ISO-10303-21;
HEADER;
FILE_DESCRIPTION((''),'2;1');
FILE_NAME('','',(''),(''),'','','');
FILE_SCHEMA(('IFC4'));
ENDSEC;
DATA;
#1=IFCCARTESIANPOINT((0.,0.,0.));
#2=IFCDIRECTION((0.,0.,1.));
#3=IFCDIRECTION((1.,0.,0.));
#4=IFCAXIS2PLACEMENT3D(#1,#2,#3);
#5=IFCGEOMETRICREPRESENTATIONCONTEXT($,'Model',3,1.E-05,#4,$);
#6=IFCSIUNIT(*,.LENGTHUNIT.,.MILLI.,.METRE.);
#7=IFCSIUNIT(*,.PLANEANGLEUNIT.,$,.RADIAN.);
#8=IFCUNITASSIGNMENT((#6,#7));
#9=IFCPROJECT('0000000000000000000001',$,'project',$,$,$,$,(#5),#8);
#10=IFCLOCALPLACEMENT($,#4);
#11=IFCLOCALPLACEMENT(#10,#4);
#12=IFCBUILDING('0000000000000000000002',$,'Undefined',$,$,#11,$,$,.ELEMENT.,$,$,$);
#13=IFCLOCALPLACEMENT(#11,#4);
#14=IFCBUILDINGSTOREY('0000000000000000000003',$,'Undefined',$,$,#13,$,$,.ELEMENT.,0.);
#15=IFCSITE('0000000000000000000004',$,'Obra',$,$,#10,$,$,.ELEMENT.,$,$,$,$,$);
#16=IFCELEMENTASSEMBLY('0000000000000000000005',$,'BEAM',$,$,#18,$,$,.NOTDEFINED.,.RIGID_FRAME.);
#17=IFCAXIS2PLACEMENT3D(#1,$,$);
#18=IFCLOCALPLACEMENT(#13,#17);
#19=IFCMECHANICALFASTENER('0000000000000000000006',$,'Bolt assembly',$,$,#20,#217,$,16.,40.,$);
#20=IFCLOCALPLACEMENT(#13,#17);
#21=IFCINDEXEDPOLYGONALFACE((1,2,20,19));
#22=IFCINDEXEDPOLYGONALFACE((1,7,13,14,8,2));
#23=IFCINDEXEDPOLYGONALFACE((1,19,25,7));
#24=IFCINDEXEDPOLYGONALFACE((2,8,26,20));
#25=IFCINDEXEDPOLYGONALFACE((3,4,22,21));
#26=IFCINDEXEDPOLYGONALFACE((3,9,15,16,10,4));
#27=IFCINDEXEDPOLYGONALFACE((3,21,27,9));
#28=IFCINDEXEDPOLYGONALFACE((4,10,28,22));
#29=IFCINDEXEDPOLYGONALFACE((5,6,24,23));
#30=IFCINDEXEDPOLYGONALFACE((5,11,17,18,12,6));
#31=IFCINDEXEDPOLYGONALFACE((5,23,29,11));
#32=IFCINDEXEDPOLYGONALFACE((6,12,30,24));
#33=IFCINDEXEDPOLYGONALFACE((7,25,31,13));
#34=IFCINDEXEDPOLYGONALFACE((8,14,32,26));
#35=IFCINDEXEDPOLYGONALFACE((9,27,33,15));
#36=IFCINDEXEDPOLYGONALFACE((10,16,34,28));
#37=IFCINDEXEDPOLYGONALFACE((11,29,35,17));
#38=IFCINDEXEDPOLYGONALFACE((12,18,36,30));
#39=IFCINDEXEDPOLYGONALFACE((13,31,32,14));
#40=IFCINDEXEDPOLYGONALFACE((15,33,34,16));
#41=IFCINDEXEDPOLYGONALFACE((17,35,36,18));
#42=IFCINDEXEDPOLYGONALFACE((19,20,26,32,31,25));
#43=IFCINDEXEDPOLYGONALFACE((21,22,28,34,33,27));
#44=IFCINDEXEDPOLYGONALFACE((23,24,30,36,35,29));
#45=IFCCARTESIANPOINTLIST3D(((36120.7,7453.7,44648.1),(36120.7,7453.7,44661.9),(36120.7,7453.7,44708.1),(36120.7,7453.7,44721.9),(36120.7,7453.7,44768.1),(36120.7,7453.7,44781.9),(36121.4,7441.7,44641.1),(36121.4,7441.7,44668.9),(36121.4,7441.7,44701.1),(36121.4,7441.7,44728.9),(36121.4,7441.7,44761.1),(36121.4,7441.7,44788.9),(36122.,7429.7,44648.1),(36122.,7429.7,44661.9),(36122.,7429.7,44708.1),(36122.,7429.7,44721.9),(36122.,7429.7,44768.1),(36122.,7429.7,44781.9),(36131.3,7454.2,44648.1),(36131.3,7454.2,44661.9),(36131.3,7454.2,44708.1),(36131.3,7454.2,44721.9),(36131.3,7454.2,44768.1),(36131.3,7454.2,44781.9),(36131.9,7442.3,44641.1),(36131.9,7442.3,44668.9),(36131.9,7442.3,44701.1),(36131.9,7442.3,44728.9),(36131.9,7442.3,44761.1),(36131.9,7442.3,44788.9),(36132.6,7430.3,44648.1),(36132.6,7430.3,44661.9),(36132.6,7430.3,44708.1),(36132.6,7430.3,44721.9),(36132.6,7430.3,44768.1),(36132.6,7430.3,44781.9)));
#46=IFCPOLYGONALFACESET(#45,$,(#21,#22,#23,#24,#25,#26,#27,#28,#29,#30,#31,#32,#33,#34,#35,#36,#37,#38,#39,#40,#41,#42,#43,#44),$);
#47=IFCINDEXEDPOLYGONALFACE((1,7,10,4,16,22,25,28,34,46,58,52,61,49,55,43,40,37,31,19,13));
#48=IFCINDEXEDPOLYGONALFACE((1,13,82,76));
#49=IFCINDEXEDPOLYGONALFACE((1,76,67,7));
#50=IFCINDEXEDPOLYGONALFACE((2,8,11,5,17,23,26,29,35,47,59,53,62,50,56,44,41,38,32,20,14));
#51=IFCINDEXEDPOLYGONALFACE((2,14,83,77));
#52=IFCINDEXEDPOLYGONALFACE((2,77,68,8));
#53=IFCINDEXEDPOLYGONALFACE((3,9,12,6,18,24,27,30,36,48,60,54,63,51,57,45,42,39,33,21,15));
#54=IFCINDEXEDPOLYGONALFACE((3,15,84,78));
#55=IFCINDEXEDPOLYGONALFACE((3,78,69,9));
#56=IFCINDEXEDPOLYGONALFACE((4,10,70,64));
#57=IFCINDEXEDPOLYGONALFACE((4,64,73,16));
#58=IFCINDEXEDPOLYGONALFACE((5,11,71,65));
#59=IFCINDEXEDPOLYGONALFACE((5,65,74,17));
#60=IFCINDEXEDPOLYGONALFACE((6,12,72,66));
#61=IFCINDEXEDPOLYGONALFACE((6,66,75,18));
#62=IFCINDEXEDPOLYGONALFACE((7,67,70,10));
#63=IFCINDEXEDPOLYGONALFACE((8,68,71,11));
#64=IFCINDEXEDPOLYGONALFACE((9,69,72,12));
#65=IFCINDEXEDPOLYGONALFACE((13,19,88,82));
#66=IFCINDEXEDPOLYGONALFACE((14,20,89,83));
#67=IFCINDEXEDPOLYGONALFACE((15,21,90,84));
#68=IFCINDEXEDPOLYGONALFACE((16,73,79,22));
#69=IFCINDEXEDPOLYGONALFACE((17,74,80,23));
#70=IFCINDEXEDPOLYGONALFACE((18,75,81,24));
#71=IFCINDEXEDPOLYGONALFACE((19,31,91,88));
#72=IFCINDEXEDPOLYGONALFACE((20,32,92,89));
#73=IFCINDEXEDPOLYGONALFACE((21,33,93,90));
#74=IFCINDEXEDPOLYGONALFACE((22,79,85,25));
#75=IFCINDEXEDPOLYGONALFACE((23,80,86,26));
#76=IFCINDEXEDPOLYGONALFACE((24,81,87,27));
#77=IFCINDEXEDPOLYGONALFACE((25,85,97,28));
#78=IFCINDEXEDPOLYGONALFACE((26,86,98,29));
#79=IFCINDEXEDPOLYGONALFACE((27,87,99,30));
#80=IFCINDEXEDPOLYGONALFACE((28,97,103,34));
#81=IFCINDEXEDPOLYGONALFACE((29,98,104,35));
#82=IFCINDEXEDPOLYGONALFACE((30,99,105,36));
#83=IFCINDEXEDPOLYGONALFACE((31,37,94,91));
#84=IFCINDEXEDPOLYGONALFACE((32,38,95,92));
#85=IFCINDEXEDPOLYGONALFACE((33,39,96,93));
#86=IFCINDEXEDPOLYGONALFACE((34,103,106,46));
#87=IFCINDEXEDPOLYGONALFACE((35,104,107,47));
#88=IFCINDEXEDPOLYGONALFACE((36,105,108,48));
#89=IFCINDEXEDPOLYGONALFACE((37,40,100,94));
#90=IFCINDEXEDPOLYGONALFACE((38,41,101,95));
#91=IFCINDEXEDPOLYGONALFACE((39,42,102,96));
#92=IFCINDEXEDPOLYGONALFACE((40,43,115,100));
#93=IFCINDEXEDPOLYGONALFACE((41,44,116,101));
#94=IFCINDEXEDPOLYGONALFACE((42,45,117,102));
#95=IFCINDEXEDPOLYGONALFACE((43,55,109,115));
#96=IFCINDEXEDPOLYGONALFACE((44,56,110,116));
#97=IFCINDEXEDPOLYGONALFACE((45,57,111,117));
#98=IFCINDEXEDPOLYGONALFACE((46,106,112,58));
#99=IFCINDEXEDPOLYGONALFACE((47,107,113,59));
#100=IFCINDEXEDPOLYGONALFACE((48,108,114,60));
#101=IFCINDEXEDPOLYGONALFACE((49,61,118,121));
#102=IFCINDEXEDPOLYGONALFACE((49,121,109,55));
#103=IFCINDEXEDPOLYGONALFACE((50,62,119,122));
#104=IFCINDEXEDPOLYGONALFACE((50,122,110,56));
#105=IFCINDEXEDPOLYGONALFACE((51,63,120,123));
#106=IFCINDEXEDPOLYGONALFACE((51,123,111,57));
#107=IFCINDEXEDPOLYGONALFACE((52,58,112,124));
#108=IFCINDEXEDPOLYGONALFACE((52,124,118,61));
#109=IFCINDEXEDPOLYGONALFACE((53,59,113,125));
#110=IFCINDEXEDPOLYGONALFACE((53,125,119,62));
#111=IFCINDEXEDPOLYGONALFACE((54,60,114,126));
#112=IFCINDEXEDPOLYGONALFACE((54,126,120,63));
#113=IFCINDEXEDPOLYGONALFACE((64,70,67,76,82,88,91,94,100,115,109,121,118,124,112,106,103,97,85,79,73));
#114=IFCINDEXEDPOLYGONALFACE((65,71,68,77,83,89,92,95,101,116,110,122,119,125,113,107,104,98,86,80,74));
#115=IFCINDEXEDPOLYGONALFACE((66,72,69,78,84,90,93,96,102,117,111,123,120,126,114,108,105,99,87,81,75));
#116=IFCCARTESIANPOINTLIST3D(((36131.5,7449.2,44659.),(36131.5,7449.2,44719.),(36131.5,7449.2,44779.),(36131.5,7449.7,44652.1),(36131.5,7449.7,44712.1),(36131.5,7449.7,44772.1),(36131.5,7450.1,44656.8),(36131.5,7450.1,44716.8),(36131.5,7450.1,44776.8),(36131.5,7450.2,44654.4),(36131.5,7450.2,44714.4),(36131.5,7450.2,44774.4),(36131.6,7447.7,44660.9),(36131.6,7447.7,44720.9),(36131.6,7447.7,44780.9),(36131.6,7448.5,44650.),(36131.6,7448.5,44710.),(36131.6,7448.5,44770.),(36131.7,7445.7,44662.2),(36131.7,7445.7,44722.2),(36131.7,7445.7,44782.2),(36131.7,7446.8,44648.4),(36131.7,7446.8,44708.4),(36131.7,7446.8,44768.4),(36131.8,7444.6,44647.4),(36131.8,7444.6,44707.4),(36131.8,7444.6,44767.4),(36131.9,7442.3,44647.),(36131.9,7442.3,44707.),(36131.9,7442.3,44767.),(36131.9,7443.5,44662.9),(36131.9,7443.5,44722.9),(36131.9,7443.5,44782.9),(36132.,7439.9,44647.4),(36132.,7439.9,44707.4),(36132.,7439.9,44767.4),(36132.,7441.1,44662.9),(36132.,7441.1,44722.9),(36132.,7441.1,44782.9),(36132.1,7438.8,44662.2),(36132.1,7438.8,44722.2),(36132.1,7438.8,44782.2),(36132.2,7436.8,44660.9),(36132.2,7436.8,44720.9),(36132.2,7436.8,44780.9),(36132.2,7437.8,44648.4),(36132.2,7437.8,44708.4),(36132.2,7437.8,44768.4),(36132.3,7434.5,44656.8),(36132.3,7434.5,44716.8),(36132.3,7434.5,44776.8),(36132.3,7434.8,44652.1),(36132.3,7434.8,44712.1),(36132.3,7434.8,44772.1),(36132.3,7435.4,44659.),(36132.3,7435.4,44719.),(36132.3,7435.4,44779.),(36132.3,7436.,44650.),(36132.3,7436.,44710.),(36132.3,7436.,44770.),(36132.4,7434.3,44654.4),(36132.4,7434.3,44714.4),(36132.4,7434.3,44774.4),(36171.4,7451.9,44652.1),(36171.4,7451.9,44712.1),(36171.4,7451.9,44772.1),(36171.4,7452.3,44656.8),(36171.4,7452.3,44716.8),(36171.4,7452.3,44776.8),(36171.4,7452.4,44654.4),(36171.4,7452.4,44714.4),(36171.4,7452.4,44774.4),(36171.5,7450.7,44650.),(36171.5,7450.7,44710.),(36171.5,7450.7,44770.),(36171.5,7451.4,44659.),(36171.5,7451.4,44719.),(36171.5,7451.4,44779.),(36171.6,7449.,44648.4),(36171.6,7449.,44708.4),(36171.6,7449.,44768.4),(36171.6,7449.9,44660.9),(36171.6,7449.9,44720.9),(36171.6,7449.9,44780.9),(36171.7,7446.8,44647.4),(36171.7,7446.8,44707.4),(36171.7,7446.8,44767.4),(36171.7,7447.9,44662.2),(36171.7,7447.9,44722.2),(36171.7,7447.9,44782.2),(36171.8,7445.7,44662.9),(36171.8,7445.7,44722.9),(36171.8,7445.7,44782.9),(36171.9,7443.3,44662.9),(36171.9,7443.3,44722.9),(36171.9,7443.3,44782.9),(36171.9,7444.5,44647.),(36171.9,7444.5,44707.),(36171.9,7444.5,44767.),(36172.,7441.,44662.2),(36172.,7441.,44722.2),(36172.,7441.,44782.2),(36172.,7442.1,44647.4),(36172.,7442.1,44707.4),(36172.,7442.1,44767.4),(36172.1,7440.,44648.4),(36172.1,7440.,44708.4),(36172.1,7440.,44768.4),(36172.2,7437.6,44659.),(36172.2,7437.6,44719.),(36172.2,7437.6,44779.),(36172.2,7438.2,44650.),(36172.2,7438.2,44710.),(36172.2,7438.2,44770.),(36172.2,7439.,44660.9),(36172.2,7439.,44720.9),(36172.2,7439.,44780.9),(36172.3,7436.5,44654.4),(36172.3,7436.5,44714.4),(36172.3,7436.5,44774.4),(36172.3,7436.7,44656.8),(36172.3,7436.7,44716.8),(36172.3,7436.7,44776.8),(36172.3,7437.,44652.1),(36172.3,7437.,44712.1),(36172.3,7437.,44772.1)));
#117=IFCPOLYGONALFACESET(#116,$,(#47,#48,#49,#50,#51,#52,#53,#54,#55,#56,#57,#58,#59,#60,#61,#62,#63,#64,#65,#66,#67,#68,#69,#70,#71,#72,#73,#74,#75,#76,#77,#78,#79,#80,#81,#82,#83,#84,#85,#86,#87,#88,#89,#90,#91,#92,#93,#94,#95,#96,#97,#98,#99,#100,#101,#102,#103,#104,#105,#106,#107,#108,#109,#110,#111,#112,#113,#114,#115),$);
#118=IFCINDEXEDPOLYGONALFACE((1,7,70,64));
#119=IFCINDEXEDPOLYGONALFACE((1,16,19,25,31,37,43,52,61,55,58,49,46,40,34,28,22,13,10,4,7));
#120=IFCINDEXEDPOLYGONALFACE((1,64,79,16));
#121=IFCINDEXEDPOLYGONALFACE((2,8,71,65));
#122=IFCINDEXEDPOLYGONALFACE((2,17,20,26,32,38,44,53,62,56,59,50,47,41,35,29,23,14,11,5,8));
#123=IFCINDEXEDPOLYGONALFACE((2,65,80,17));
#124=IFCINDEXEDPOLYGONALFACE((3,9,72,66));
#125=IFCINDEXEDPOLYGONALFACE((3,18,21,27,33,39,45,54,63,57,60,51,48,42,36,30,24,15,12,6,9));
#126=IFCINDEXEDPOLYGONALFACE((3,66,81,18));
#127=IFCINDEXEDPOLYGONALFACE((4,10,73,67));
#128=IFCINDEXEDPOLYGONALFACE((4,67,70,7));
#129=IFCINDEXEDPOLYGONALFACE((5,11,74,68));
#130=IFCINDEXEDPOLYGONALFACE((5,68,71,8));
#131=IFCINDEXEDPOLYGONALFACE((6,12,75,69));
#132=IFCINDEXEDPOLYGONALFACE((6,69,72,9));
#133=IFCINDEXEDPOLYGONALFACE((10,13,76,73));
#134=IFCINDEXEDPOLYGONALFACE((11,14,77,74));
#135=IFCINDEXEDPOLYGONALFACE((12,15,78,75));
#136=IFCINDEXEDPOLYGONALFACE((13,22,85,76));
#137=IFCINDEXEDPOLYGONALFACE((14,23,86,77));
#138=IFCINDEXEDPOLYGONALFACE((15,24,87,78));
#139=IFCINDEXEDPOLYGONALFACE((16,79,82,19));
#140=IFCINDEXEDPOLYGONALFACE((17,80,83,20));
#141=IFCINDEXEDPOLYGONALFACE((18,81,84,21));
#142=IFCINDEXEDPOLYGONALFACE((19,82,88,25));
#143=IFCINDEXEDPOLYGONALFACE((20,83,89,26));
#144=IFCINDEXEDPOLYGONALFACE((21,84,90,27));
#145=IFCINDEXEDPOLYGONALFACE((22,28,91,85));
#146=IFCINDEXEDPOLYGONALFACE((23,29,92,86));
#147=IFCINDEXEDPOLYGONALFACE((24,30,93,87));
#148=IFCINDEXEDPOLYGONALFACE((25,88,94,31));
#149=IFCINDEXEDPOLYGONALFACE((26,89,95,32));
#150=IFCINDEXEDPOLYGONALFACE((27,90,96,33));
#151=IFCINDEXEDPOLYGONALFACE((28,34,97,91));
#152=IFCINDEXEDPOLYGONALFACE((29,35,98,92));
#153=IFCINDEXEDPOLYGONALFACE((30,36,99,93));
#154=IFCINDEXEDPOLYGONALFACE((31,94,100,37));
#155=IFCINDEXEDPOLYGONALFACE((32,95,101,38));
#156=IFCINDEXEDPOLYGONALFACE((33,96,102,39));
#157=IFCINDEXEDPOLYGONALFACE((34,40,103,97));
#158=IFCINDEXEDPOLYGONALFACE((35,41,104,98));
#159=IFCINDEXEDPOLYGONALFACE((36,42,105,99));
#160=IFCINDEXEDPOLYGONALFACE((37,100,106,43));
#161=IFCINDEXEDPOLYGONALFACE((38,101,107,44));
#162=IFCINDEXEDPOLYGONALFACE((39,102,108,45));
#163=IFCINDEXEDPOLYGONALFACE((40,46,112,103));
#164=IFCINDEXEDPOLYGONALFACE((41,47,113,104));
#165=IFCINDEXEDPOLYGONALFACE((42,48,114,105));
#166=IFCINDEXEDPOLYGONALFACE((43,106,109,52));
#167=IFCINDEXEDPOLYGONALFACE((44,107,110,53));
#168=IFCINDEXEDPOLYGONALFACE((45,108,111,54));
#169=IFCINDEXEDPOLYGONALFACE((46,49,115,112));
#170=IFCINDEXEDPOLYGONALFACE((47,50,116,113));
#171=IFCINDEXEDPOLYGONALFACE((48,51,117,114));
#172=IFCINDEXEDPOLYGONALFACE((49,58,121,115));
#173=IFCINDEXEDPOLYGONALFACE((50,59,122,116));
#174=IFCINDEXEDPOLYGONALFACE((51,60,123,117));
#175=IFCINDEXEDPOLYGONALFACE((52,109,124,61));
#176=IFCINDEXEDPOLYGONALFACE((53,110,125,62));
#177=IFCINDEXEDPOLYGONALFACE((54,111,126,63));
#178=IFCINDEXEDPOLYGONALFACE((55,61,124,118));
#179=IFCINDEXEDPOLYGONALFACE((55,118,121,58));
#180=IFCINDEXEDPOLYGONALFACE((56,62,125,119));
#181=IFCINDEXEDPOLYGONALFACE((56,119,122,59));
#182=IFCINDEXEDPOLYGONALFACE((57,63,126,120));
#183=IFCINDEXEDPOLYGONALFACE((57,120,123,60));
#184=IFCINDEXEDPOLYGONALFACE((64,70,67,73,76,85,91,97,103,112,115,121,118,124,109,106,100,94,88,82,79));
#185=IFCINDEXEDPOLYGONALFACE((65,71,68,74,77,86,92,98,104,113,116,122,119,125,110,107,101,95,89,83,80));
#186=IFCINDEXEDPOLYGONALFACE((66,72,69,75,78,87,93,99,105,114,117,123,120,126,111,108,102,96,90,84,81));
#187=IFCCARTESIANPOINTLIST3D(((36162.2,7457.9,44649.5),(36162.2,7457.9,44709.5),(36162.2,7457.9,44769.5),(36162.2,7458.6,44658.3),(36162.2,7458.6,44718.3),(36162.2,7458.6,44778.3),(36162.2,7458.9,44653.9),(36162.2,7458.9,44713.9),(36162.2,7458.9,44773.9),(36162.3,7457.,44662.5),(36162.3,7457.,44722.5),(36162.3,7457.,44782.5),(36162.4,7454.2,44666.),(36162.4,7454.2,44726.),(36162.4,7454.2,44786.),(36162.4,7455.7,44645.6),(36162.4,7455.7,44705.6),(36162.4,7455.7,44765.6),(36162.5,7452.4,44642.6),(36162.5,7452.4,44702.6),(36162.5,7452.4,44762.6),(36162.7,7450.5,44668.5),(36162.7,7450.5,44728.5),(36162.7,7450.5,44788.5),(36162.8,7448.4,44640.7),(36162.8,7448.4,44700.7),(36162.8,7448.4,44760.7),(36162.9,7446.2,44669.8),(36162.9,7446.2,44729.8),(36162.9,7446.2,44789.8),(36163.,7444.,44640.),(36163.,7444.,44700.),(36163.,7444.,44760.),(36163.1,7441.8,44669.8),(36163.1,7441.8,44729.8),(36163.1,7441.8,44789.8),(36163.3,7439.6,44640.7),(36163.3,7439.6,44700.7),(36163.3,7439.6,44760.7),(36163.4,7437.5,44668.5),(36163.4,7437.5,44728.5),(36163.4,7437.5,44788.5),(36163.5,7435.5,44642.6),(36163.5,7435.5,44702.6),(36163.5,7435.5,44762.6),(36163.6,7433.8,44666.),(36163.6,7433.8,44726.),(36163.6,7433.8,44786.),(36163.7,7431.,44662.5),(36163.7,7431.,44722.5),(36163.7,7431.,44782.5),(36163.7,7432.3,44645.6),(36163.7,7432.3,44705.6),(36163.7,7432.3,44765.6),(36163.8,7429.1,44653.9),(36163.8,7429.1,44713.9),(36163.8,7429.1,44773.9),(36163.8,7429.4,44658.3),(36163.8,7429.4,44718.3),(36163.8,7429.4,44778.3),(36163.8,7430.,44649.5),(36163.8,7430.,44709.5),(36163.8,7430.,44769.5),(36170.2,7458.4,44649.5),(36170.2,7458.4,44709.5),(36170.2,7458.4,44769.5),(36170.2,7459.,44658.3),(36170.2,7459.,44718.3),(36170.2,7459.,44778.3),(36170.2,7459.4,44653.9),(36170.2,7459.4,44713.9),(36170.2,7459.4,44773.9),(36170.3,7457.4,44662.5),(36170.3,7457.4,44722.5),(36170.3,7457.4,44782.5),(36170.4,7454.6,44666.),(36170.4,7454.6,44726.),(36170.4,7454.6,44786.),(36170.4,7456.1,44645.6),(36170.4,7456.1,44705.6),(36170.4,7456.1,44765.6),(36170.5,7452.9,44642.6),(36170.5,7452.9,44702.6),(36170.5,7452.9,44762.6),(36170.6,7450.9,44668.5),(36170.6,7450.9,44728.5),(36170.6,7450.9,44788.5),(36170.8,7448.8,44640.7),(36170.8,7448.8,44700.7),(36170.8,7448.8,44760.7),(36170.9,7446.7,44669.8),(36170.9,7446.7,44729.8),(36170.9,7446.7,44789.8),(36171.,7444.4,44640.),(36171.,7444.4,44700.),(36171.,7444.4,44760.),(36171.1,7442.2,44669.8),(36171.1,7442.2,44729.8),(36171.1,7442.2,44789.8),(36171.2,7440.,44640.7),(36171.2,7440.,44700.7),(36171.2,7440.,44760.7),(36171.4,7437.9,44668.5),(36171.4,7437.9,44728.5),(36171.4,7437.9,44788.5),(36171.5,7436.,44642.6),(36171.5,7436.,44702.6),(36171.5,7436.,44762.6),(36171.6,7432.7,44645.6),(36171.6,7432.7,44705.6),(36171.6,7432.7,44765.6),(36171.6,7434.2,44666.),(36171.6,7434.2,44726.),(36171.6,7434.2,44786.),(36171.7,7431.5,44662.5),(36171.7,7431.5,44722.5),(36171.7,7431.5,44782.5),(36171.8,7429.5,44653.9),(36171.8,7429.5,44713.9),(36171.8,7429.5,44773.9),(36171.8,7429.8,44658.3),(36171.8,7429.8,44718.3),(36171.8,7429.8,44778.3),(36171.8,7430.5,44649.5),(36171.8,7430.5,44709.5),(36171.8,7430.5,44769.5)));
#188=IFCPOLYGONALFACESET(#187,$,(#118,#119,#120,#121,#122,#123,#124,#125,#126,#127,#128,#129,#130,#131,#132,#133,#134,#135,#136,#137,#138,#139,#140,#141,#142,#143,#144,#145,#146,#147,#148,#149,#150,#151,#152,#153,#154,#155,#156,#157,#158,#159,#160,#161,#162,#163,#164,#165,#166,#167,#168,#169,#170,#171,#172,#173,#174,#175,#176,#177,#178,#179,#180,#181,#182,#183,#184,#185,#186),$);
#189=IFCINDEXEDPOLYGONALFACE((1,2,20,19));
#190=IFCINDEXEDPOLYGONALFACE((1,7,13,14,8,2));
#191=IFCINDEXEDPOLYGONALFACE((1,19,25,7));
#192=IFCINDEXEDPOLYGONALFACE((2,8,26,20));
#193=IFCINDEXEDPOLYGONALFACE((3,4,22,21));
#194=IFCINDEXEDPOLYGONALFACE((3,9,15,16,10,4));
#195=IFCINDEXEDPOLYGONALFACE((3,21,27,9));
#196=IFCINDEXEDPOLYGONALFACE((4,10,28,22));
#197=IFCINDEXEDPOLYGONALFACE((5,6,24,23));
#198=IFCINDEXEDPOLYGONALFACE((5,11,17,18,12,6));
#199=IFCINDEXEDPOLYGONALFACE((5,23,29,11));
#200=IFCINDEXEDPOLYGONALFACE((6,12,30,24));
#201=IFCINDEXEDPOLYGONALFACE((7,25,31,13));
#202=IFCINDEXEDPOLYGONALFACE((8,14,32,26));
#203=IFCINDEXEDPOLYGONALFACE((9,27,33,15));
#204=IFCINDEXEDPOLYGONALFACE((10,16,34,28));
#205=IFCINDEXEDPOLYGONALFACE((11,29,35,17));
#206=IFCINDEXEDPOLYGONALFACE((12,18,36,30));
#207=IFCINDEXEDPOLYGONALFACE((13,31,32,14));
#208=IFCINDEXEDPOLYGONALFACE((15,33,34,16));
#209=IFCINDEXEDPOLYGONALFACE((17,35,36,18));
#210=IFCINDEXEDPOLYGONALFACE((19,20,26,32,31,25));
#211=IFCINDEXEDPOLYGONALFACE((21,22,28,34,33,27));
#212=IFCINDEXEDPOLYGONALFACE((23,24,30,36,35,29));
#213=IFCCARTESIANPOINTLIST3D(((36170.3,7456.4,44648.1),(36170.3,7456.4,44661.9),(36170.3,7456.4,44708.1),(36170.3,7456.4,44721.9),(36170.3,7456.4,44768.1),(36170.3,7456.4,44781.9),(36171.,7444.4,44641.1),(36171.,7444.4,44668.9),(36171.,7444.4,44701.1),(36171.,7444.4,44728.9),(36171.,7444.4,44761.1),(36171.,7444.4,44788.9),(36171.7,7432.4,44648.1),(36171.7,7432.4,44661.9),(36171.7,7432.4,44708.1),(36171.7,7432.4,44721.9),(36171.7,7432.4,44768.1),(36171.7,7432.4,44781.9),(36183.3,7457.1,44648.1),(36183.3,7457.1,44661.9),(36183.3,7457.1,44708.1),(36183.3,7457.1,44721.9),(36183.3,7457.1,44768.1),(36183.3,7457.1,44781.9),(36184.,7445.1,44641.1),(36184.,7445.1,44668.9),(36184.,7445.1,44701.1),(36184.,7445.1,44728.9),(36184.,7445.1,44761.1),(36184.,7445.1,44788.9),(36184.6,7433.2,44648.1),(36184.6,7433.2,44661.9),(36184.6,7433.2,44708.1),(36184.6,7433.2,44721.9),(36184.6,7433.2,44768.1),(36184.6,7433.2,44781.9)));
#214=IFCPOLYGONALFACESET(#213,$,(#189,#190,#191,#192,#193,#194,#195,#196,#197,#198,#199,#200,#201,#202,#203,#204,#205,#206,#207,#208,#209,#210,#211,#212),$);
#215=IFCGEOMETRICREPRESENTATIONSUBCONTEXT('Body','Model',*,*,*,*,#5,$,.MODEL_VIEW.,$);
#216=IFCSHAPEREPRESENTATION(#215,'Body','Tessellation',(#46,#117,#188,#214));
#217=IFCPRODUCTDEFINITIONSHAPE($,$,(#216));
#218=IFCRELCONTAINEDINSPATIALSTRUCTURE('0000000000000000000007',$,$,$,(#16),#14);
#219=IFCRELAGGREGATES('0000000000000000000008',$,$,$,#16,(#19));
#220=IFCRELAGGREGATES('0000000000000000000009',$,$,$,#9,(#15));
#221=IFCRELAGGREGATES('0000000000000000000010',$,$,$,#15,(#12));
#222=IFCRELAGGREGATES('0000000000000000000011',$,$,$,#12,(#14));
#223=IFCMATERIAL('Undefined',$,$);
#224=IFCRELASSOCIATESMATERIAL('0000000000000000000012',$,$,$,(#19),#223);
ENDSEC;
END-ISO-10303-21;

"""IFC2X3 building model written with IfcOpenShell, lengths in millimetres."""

from ifc_helpers import new_model, si_unit, frame, origin_with_axes, origin_2d_with_axis, place, context, subcontext, project, spatial, polyline, circle, outline, extrude, source, transform, mapped, material, element, aggregate, save


model = new_model("IFC2X3")

# Units and contexts
model_context = context("Model", 3, precision=1e-05, world=origin_with_axes())
body_context = subcontext(model_context, "Body", "Model", "MODEL_VIEW")
ifc_project = project(units=[si_unit("LENGTHUNIT", "METRE", prefix="MILLI"), si_unit("PLANEANGLEUNIT", "RADIAN")], contexts=[model_context])

# Site, building, storey
site_placement = place(None, origin_with_axes())
site = spatial("IfcSite", under=ifc_project, at=site_placement, Name="Obra", CompositionType="ELEMENT")
building_placement = place(site_placement, origin_with_axes())
building = spatial("IfcBuilding", under=site, at=building_placement, Name="Undefined", CompositionType="ELEMENT")
storey_placement = place(building_placement, origin_with_axes())
storey = spatial("IfcBuildingStorey", under=building, at=storey_placement, Name="Undefined", CompositionType="ELEMENT", Elevation=0.0)

# Element assembly
assembly_1_placement = place(storey_placement, origin_with_axes())
assembly_1 = element("IfcElementAssembly", 1, at=assembly_1_placement, inside=storey, Name="BEAM", AssemblyPlace="NOTDEFINED", PredefinedType="RIGID_FRAME")

# Mechanical fastener
ifc_material_1 = material(Name="Undefined")
shared_shape_1 = source(origin_with_axes(), body_context, "Body", "SweptSolid", [
    extrude(outline(polyline([(13.9, 0.0), (6.9, 12.0), (-6.9, 12.0), (-13.9, 0.0), (-6.9, -12.0), (6.9, -12.0), (13.9, 0.0)])), frame((0.0, -44.8, 0.0), z_axis=(0.0, 1.0, 0.0), x_axis=(1.0, 0.0, 0.0)), (0.0, 0.0, 1.0), 10.6),
    extrude(circle(Radius=8.0, at=origin_2d_with_axis()), frame((0.0, -34.2, 0.0), z_axis=(0.0, 1.0, 0.0), x_axis=(1.0, 0.0, 0.0)), (0.0, 0.0, 1.0), 40.0),
    extrude(circle(Radius=15.0, at=origin_2d_with_axis()), frame((0.0, -3.1, 0.0), z_axis=(0.0, 1.0, 0.0), x_axis=(1.0, 0.0, 0.0)), (0.0, 0.0, 1.0), 8.0),
    extrude(outline(polyline([(13.9, 0.0), (6.9, 12.0), (-6.9, 12.0), (-13.9, 0.0), (-6.9, -12.0), (6.9, -12.0), (13.9, 0.0)])), frame((0.0, 4.9, 0.0), z_axis=(0.0, 1.0, 0.0), x_axis=(1.0, 0.0, 0.0)), (0.0, 0.0, 1.0), 13.0),
])
mechanical_fastener_placement = place(assembly_1_placement, frame((36163.3, 7494.1, 44835.0), z_axis=(0.055152, -0.998478, 0.0), x_axis=(0.0, 0.0, -1.0)))
mechanical_fastener = element("IfcMechanicalFastener", 2, at=mechanical_fastener_placement, material=ifc_material_1, Name="Bolt assembly", NominalDiameter=16.0, NominalLength=40.0, context=body_context, shape_type="MappedRepresentation", body=[
    mapped(shared_shape_1, transform((60.0, 0.0, 50.0))),
    mapped(shared_shape_1, transform((120.0, 0.0, 50.0))),
    mapped(shared_shape_1, transform((180.0, 0.0, 50.0))),
])
aggregate(assembly_1, [mechanical_fastener])

save(model, "model.ifc")
